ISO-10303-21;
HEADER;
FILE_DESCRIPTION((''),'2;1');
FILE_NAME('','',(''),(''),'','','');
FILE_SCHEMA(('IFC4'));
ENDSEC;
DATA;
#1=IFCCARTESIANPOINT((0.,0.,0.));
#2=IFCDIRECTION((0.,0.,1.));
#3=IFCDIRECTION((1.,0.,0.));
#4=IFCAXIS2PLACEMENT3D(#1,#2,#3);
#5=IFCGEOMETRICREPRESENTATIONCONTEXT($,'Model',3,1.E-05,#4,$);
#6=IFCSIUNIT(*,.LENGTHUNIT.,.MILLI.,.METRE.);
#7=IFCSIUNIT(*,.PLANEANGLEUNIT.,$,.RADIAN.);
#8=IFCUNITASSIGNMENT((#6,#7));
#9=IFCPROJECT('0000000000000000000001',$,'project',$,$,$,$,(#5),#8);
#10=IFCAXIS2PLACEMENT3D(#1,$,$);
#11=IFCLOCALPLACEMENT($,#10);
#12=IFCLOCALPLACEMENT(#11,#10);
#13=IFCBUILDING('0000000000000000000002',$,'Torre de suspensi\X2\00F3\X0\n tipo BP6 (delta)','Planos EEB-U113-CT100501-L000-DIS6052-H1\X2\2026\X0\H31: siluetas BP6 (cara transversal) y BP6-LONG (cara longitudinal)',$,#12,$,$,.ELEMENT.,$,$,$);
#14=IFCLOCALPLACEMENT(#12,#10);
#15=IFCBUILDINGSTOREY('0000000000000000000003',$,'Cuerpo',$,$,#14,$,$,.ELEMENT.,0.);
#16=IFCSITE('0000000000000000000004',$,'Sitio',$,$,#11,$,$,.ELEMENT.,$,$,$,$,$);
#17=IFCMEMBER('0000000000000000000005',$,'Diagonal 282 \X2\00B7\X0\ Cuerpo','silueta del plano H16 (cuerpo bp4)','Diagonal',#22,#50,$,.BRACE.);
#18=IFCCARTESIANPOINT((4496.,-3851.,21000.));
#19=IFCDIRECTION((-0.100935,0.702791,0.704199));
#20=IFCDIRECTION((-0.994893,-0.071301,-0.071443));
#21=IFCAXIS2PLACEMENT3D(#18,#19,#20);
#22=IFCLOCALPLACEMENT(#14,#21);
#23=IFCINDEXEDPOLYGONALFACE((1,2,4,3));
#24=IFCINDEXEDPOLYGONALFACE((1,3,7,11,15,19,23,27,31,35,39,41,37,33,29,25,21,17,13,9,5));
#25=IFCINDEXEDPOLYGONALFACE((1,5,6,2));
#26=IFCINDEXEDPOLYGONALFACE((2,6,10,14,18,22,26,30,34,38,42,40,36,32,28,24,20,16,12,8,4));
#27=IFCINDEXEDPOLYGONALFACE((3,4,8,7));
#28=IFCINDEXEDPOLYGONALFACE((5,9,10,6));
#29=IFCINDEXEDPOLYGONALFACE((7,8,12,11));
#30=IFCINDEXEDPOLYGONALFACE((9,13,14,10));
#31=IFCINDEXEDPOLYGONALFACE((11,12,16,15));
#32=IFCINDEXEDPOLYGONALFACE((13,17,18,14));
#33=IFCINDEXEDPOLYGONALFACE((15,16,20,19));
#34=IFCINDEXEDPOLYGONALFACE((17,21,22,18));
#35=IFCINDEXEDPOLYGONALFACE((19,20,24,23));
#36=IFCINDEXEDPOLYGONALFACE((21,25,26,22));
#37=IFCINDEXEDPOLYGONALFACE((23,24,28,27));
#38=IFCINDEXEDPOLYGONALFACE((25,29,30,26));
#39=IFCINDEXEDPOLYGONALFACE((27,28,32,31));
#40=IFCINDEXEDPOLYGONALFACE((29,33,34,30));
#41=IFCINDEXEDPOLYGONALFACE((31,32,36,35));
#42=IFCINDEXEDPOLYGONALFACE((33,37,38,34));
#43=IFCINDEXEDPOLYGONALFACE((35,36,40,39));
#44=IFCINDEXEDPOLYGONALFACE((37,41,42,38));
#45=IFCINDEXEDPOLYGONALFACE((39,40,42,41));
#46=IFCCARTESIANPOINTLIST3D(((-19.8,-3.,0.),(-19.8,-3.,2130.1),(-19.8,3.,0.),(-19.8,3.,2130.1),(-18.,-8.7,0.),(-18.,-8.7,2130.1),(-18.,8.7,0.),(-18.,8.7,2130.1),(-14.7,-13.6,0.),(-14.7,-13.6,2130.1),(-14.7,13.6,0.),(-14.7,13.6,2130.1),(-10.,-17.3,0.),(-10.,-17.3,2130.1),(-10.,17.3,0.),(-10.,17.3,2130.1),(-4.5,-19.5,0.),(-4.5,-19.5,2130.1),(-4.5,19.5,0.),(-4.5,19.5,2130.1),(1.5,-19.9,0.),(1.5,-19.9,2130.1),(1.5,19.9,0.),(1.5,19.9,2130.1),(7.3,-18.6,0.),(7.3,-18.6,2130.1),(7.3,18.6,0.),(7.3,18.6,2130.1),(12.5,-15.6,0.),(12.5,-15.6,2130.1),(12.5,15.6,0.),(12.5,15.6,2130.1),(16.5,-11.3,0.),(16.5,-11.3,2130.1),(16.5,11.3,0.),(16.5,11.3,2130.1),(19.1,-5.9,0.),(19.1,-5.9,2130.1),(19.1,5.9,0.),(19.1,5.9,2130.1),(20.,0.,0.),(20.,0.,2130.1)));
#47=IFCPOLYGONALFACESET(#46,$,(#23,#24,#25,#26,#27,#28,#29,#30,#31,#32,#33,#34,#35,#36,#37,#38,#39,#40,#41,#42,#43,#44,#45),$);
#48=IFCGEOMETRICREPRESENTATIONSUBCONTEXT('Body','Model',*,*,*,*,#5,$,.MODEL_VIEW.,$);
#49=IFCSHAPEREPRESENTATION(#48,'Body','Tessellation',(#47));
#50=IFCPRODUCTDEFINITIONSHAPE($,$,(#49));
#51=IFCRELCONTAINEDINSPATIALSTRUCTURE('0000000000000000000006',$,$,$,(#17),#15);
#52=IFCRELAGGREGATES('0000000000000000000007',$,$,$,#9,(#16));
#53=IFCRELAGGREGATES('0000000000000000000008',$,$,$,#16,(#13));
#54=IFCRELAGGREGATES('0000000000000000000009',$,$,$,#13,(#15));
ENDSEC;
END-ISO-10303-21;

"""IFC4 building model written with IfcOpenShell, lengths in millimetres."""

from ifc_helpers import new_model, si_unit, frame, origin, origin_with_axes, place, context, subcontext, project, spatial, circle, extrude, element, save


model = new_model("IFC4")

# Units and contexts
model_context = context("Model", 3, precision=1e-05, world=origin_with_axes())
body_context = subcontext(model_context, "Body", "Model", "MODEL_VIEW")
ifc_project = project(units=[si_unit("LENGTHUNIT", "METRE", prefix="MILLI"), si_unit("PLANEANGLEUNIT", "RADIAN")], contexts=[model_context])

# Site, building, storey
site_placement = place(None, origin())
site = spatial("IfcSite", under=ifc_project, at=site_placement, Name="Sitio", CompositionType="ELEMENT")
building_placement = place(site_placement, origin())
building = spatial("IfcBuilding", under=site, at=building_placement, Name="Torre de suspensión tipo BP6 (delta)", Description="Planos EEB-U113-CT100501-L000-DIS6052-H1…H31: siluetas BP6 (cara transversal) y BP6-LONG (cara longitudinal)", CompositionType="ELEMENT")
storey_placement = place(building_placement, origin())
storey = spatial("IfcBuildingStorey", under=building, at=storey_placement, Name="Cuerpo", CompositionType="ELEMENT", Elevation=0.0)

# Member
member_1_placement = place(storey_placement, frame((4496.0, -3851.0, 21000.0), z_axis=(-0.100935, 0.702791, 0.704199), x_axis=(-0.994893, -0.071301, -0.071443)))
element("IfcMember", 1, at=member_1_placement, inside=storey, Name="Diagonal 282 · Cuerpo", Description="silueta del plano H16 (cuerpo bp4)", ObjectType="Diagonal", PredefinedType="BRACE", context=body_context, shape_type="SweptSolid", body=[
    extrude(circle(Radius=20.0), None, (0.0, 0.0, 1.0), 2130.1),
])

save(model, "model.ifc")
